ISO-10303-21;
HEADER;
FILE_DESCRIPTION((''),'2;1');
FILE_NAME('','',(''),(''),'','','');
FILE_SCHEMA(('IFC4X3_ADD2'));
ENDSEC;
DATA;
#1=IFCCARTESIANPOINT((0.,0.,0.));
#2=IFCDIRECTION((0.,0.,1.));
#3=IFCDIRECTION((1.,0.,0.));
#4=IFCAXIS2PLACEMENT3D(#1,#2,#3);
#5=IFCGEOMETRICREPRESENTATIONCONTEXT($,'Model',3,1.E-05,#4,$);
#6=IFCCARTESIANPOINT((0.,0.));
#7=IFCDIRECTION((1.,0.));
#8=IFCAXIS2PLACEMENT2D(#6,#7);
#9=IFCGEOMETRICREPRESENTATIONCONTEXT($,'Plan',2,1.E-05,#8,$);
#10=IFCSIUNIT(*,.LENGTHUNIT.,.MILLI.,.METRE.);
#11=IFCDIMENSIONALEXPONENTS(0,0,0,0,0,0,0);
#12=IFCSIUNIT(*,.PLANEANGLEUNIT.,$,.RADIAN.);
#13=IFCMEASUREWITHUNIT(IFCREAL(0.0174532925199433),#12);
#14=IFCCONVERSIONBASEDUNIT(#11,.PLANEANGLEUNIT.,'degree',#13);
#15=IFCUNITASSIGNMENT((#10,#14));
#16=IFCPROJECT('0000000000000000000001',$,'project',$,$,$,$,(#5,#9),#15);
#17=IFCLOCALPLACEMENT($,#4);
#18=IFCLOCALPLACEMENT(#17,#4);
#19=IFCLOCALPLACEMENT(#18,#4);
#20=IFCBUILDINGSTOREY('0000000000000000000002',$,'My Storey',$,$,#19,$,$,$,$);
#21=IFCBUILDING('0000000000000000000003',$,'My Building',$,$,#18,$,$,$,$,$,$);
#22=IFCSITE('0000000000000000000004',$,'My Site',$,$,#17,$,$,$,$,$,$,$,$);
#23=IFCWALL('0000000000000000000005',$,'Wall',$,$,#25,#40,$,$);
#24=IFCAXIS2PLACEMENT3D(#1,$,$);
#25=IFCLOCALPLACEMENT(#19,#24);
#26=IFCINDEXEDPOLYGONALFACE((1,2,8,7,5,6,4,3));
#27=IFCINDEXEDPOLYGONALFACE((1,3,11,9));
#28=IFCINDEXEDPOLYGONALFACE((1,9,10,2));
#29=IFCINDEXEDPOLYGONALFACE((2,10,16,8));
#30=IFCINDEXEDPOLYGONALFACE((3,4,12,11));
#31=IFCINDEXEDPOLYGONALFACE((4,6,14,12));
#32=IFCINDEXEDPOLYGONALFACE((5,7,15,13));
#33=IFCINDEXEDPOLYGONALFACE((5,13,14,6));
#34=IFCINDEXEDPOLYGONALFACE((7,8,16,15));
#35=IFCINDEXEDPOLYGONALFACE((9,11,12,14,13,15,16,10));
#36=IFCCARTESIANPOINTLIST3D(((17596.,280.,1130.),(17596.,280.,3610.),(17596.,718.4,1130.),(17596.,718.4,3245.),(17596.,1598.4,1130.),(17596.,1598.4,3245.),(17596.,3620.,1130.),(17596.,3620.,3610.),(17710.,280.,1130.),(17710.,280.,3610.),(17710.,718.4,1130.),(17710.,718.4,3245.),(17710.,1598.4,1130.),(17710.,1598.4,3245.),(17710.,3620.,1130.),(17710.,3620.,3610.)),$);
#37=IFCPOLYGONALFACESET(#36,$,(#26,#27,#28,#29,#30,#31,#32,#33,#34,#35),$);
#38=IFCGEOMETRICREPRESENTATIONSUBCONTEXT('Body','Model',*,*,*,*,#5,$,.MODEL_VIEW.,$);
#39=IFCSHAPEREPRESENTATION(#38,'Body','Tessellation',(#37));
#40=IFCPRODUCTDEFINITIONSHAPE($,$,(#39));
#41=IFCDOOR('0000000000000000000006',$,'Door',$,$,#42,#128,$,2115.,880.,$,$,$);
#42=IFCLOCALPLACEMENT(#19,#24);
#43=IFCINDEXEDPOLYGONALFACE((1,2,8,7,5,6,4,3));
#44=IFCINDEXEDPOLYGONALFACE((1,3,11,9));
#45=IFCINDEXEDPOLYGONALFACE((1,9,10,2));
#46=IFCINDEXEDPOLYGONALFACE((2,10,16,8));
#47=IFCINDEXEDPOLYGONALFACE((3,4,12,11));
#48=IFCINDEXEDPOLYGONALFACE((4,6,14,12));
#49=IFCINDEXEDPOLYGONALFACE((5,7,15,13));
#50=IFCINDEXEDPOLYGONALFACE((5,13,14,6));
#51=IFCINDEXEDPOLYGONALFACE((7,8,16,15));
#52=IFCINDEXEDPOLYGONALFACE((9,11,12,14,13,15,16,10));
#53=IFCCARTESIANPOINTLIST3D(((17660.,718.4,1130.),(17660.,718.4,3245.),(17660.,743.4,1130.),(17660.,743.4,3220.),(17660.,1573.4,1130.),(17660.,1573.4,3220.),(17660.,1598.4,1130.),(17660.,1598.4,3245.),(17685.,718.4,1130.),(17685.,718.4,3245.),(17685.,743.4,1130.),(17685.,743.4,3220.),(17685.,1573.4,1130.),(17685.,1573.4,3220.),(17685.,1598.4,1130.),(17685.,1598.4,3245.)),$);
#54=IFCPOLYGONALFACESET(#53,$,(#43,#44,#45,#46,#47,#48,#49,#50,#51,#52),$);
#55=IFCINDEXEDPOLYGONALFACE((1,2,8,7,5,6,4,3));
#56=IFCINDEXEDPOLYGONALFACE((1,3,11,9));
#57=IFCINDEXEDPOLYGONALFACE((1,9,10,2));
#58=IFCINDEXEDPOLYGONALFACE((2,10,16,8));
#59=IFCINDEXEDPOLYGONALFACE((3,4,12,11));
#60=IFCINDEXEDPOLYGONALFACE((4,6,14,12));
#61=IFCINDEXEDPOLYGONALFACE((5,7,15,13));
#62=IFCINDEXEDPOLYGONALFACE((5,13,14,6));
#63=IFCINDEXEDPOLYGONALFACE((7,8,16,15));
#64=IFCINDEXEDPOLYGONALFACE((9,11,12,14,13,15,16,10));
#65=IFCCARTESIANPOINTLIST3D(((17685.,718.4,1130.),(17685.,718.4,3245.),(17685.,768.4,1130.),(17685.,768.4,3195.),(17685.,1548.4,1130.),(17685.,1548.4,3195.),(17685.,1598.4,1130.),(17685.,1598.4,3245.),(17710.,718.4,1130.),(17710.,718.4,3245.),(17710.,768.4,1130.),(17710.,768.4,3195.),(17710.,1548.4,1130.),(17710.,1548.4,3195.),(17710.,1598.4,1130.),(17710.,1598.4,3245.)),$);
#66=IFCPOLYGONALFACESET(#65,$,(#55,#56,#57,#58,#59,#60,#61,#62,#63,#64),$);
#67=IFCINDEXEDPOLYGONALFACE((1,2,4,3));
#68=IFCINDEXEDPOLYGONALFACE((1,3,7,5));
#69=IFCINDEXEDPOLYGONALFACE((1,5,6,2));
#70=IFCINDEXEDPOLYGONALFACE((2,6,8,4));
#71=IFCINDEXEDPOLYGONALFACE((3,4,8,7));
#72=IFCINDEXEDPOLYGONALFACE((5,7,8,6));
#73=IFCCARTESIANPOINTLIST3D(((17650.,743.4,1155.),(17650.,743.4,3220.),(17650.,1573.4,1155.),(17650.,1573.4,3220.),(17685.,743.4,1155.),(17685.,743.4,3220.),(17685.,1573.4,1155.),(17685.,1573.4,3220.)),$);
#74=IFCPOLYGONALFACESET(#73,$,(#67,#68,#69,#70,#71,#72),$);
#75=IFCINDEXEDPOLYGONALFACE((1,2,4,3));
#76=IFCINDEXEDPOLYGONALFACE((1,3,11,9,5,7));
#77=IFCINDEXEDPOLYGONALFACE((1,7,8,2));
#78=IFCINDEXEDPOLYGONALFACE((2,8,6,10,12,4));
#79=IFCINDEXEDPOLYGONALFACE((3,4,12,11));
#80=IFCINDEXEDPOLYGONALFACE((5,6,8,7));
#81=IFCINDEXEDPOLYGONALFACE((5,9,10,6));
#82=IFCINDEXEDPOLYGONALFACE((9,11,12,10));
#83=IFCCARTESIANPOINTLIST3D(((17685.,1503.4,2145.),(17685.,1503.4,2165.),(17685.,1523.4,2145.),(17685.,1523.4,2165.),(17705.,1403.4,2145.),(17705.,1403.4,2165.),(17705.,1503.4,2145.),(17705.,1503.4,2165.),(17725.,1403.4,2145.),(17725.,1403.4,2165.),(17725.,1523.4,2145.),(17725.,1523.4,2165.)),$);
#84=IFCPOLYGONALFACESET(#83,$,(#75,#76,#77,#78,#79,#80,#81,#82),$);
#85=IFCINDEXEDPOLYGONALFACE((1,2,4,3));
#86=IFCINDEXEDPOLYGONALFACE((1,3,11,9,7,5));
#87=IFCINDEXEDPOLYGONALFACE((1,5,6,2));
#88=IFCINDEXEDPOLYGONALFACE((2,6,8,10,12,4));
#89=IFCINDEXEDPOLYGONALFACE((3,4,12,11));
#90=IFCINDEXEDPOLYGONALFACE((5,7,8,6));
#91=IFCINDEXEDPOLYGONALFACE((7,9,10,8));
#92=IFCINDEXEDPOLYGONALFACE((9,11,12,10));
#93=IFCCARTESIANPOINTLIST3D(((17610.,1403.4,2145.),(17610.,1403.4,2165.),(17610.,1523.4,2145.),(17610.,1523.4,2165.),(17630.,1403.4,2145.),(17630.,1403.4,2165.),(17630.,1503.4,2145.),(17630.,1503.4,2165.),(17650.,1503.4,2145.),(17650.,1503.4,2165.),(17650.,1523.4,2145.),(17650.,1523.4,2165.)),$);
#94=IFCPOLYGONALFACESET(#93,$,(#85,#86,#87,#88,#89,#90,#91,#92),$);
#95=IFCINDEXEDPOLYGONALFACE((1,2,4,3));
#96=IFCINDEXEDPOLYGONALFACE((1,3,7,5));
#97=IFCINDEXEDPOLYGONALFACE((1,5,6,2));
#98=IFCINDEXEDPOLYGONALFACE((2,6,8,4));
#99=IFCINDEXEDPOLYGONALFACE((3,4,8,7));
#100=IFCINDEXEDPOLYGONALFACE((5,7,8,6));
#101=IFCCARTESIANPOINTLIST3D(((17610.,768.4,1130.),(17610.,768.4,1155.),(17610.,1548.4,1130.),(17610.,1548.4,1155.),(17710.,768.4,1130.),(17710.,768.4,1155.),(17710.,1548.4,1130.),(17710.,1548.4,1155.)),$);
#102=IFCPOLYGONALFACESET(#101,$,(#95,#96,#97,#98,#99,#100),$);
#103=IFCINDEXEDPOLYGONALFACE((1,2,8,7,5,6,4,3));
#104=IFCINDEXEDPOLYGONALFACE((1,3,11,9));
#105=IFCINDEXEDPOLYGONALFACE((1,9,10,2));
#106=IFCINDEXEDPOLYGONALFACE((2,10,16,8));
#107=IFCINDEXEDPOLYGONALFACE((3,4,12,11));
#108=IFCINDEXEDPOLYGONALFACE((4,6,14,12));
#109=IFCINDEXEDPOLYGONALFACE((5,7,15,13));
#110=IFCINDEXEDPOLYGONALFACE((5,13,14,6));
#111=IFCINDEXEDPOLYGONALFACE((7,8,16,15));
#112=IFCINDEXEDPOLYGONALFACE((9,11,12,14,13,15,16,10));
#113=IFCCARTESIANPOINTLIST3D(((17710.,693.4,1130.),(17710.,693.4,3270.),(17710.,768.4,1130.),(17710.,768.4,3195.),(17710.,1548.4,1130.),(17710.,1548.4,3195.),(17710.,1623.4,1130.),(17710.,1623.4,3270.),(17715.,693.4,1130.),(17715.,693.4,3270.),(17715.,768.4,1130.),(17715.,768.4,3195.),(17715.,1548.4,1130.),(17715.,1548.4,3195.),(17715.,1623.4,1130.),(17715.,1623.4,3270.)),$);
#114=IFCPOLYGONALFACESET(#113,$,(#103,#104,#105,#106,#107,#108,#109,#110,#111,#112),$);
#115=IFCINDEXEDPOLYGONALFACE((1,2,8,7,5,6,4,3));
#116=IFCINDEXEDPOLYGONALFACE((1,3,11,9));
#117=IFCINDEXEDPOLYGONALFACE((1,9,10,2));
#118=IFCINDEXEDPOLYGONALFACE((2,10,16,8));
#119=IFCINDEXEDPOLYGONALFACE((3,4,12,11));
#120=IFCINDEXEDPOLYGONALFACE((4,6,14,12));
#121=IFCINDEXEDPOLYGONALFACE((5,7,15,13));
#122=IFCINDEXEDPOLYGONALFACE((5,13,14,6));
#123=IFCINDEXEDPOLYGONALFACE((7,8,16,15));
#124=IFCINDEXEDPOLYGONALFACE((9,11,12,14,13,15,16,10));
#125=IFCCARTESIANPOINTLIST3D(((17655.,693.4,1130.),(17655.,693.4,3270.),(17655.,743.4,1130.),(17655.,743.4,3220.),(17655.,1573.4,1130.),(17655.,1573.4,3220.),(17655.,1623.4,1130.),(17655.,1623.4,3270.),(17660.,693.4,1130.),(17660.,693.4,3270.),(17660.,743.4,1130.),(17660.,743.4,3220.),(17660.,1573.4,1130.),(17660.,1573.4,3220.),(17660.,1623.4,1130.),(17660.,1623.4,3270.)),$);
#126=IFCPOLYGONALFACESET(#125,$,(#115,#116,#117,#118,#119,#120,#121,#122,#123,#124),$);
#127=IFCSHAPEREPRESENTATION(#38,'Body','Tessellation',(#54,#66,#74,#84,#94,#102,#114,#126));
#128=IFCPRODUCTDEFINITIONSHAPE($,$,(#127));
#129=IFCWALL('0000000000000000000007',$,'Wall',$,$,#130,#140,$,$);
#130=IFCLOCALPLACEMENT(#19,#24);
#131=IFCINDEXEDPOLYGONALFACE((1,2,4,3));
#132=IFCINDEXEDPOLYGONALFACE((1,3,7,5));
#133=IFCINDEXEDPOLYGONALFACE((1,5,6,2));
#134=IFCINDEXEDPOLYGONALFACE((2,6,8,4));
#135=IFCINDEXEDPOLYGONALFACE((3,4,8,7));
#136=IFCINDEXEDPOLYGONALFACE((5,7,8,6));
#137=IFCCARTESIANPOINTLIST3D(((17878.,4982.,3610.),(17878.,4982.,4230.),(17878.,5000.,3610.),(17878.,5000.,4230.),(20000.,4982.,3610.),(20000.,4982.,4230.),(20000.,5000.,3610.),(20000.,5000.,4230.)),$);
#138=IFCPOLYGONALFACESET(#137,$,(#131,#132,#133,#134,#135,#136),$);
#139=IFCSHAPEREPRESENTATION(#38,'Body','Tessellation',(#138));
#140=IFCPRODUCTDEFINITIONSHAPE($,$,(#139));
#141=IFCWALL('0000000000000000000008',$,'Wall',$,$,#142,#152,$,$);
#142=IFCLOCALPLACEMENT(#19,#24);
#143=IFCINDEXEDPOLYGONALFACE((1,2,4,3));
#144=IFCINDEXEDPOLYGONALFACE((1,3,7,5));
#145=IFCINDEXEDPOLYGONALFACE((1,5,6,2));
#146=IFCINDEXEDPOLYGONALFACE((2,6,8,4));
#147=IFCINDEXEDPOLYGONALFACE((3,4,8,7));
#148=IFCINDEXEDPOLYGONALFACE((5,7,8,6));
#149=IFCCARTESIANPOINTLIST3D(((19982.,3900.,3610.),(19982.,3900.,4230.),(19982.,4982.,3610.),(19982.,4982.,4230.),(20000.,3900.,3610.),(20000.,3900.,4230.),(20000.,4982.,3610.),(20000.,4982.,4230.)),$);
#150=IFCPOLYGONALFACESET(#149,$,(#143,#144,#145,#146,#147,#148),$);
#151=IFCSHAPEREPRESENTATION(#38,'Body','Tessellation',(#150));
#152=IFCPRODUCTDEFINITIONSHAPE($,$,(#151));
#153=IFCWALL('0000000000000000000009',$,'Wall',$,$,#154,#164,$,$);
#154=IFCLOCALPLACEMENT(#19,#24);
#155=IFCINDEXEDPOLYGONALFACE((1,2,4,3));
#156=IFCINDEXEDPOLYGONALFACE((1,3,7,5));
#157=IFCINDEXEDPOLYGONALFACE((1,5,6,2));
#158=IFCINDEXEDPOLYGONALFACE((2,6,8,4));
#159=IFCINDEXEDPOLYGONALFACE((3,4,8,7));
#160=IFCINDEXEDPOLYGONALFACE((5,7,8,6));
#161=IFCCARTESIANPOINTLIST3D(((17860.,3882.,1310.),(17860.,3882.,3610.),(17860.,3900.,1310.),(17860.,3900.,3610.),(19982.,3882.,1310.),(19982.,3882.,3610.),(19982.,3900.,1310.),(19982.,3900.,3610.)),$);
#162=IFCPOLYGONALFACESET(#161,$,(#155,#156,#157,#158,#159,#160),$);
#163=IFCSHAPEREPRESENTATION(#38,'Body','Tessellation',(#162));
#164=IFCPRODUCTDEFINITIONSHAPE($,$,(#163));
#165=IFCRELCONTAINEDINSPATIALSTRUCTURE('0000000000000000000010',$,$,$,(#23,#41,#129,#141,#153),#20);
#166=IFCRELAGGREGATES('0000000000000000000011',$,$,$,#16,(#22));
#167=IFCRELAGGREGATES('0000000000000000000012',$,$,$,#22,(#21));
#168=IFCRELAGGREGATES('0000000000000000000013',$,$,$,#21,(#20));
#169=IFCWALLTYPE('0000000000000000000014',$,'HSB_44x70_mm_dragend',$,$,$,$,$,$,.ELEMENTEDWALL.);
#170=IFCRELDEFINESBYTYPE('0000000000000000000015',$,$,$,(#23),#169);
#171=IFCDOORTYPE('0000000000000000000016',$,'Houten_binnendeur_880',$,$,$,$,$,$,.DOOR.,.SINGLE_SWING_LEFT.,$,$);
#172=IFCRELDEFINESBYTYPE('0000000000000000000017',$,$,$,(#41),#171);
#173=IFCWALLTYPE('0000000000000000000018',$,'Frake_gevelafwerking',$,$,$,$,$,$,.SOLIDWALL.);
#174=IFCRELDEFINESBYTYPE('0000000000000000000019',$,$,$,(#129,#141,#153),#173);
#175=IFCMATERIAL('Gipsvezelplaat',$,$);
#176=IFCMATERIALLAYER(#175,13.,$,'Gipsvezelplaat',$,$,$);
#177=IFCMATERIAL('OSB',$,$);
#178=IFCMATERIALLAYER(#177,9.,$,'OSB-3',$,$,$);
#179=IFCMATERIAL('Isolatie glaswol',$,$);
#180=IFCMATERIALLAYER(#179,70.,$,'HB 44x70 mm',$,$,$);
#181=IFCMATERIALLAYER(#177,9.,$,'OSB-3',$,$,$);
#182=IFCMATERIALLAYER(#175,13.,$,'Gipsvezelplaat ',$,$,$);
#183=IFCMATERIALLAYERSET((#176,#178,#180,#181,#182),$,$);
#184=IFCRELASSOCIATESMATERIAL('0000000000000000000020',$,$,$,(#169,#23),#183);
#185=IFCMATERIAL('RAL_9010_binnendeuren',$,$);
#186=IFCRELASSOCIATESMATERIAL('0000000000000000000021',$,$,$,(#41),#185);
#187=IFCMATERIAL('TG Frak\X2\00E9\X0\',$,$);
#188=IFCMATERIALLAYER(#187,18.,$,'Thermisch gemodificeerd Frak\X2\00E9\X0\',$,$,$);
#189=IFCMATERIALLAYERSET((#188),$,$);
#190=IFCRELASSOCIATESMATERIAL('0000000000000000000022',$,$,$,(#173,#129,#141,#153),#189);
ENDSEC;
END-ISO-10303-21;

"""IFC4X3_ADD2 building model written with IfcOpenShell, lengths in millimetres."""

from ifc_helpers import new_model, entity, si_unit, converted_unit, frame, origin_with_axes, origin_2d_with_axis, place, context, subcontext, project, spatial, line, indexed_curve, outline, extrude, shape, source, transform, mapped, material, layer, layer_set, layer_usage, type_object, type_shapes, element, fill, save


model = new_model("IFC4X3_ADD2")

# Units and contexts
model_context = context("Model", 3, precision=1e-05, world=origin_with_axes())
plan_context = context("Plan", 2, precision=1e-05, world=origin_2d_with_axis())
body_context_1 = subcontext(model_context, "Body", "Model", "MODEL_VIEW")
body_context_2 = subcontext(plan_context, "Body", "Plan", "PLAN_VIEW")
ifc_project = project(units=[si_unit("LENGTHUNIT", "METRE", prefix="MILLI"), converted_unit("PLANEANGLEUNIT", "degree", entity("IfcReal", 0.0174532925199433), si_unit("PLANEANGLEUNIT", "RADIAN"), dimensions=[0, 0, 0, 0, 0, 0, 0])], contexts=[model_context, plan_context])

# Site, building, storey
site_placement = place(None, origin_with_axes())
site = spatial("IfcSite", under=ifc_project, at=site_placement, Name="My Site")
building_placement = place(site_placement, origin_with_axes())
building = spatial("IfcBuilding", under=site, at=building_placement, Name="My Building")
storey_placement = place(building_placement, origin_with_axes())
storey = spatial("IfcBuildingStorey", under=building, at=storey_placement, Name="My Storey")

# Shared definitions
ifc_material_1 = material(Name="Isolatie glaswol")

# Shared definitions
ifc_material_2 = material(Name="OSB")
ifc_material_3 = material(Name="Gipsvezelplaat")

# Wall, opening, door
shared_shape_1 = source(origin_with_axes(), body_context_1, "Body", "SweptSolid", [
    extrude(outline(indexed_curve([(0.0, 0.0), (880.0, 0.0), (880.0, 2115.0), (0.0, 2115.0)], segments=[line(1, 2, 3, 4, 1)])), frame((0.0, -600.0, 0.0), z_axis=(0.0, -1.0, 0.0), x_axis=(1.0, 0.0, 0.0)), (0.0, 0.0, -1.0), 1200.0),
])
ifc_material_4 = material(Name="RAL_9010_binnendeuren")
door_type_1 = type_object("IfcDoorType", Name="Houten_binnendeur_880", OperationType="SINGLE_SWING_LEFT", PredefinedType="DOOR")
shared_shape_2 = source(origin_with_axes(), body_context_1, "Body", "SweptSolid", [
    extrude(outline(indexed_curve([(0.0, 0.0), (0.0, 2115.0), (880.0, 2115.0), (880.0, 0.0), (855.0, 0.0), (855.0, 2090.0), (25.0, 2090.0), (25.0, 0.0)], segments=[line(1, 2, 3, 4, 5, 6, 7, 8, 1)])), frame((0.0, 25.0, 0.0), z_axis=(0.0, -1.0, 0.0), x_axis=(1.0, 0.0, 0.0)), (0.0, 0.0, -1.0), 25.0),
    extrude(outline(indexed_curve([(0.0, 0.0), (0.0, 2115.0), (880.0, 2115.0), (880.0, 0.0), (830.0, 0.0), (830.0, 2065.0), (50.0, 2065.0), (50.0, 0.0)], segments=[line(1, 2, 3, 4, 5, 6, 7, 8, 1)])), frame((0.0, 0.0, 0.0), z_axis=(0.0, -1.0, 0.0), x_axis=(1.0, 0.0, 0.0)), (0.0, 0.0, -1.0), 25.0),
    extrude(outline(indexed_curve([(0.0, 0.0), (830.0, 0.0), (830.0, 35.0), (0.0, 35.0)], segments=[line(1, 2, 3, 4, 1)])), frame((25.0, 25.0, 25.0), z_axis=(0.0, 0.0, 1.0), x_axis=(1.0, 0.0, 0.0)), (0.0, 0.0, 1.0), 2065.0),
    extrude(outline(indexed_curve([(0.0, 0.0), (0.0, -40.0), (-120.0, -40.0), (-120.0, -20.0), (-20.0, -20.0), (-20.0, 0.0)], segments=[line(1, 2, 3, 4, 5, 6, 1)])), frame((805.0, 25.0, 1015.0), z_axis=(0.0, 0.0, 1.0), x_axis=(1.0, 0.0, 0.0)), (0.0, 0.0, 1.0), 20.0),
    extrude(outline(indexed_curve([(0.0, 0.0), (0.0, 40.0), (-120.0, 40.0), (-120.0, 20.0), (-20.0, 20.0), (-20.0, 0.0)], segments=[line(1, 2, 3, 4, 5, 6, 1)])), frame((805.0, 60.0, 1015.0), z_axis=(0.0, 0.0, 1.0), x_axis=(1.0, 0.0, 0.0)), (0.0, 0.0, 1.0), 20.0),
    extrude(outline(indexed_curve([(0.0, 0.0), (780.0, 0.0), (780.0, 100.0), (0.0, 100.0)], segments=[line(1, 2, 3, 4, 1)])), frame((50.0, 0.0, 0.0), z_axis=(0.0, 0.0, 1.0), x_axis=(1.0, 0.0, 0.0)), (0.0, 0.0, 1.0), 25.0),
    extrude(outline(indexed_curve([(0.0, 0.0), (0.0, 2140.0), (930.0, 2140.0), (930.0, 0.0), (855.0, 0.0), (855.0, 2065.0), (75.0, 2065.0), (75.0, 0.0)], segments=[line(1, 2, 3, 4, 5, 6, 7, 8, 1)])), frame((-25.0, -5.0, 0.0), z_axis=(0.0, -1.0, 0.0), x_axis=(1.0, 0.0, 0.0)), (0.0, 0.0, -1.0), 5.0),
    extrude(outline(indexed_curve([(0.0, 0.0), (0.0, 2140.0), (930.0, 2140.0), (930.0, 0.0), (880.0, 0.0), (880.0, 2090.0), (50.0, 2090.0), (50.0, 0.0)], segments=[line(1, 2, 3, 4, 5, 6, 7, 8, 1)])), frame((-25.0, 50.0, 0.0), z_axis=(0.0, -1.0, 0.0), x_axis=(1.0, 0.0, 0.0)), (0.0, 0.0, -1.0), 5.0),
])
shared_shape_3 = source(origin_with_axes(), body_context_2, "Body", "Curve2D", [
    entity("IfcIndexedPolyCurve", entity("IfcCartesianPointList2D", [[0.0, 0.0], [0.0, 50.0], [25.0, 50.0], [25.0, 25.0], [50.0, 25.0], [50.0, 0.0]]), [entity("IfcLineIndex", [1, 2, 3, 4, 5, 6, 1])]),
    entity("IfcIndexedPolyCurve", entity("IfcCartesianPointList2D", [[880.0, 0.0], [880.0, 50.0], [855.0, 50.0], [855.0, 25.0], [830.0, 25.0], [830.0, 0.0]]), [entity("IfcLineIndex", [1, 2, 3, 4, 5, 6, 1])]),
    entity("IfcTrimmedCurve", entity("IfcEllipse", entity("IfcAxis2Placement2D", entity("IfcCartesianPoint", [60.0, 50.0]), entity("IfcDirection", [1.0, 0.0])), 795.0, 830.0), [entity("IfcCartesianPoint", [855.0, 50.0])], [entity("IfcCartesianPoint", [60.0, 880.0])], True, "CARTESIAN"),
    entity("IfcIndexedPolyCurve", entity("IfcCartesianPointList2D", [[25.0, 50.0], [60.0, 50.0], [60.0, 880.0], [25.0, 880.0]]), [entity("IfcLineIndex", [1, 2, 3, 4, 1])]),
])
type_shapes(door_type_1, [shared_shape_2, shared_shape_3])
ifc_layer_1 = layer(ifc_material_3, 13.0, Name="Gipsvezelplaat")
ifc_layer_2 = layer(ifc_material_2, 9.0, Name="OSB-3")
ifc_layer_3 = layer(ifc_material_1, 70.0, Name="HB 44x70 mm")
ifc_layer_4 = layer(ifc_material_2, 9.0, Name="OSB-3")
ifc_layer_5 = layer(ifc_material_3, 13.0, Name="Gipsvezelplaat ")
ifc_layer_set_1 = layer_set([ifc_layer_1, ifc_layer_2, ifc_layer_3, ifc_layer_4, ifc_layer_5])
ifc_layer_usage_1 = layer_usage(ifc_layer_set_1, "AXIS2", "POSITIVE", 0.0)
wall_type_1 = type_object("IfcWallType", Name="HSB_44x70_mm_dragend", PredefinedType="ELEMENTEDWALL", material=ifc_layer_set_1)
wall_1_placement = place(storey_placement, frame((17710.0, 280.0, 1130.0), z_axis=(0.0, 0.0, 1.0), x_axis=(0.0, 1.0, 0.0)))
wall_1 = element("IfcWall", 1, at=wall_1_placement, inside=storey, type_object=wall_type_1, material=ifc_layer_usage_1, Name="Wall", context=body_context_1, shape_type="SweptSolid", body=[
    extrude(outline(indexed_curve([(0.0, 0.0), (0.0, 114.0), (3340.0, 114.0), (3340.0, 0.0), (0.0, 0.0)], self_intersect=False)), origin_with_axes(), (0.0, 0.0, 1.0), 2480.0),
])
opening_1_placement = place(wall_1_placement, frame((438.4, 0.0, 0.0), z_axis=(0.0, 0.0, 1.0), x_axis=(1.0, 0.0, 0.0)))
opening_1 = element("IfcOpeningElement", 2, at=opening_1_placement, cuts=wall_1, PredefinedType="OPENING", context=body_context_1, shape_type="MappedRepresentation", body=[
    mapped(shared_shape_1, transform((0.0, 0.0, 0.0), x_axis=(1.0, 0.0, 0.0), y_axis=(0.0, 1.0, 0.0), z_axis=(0.0, 0.0, 1.0), scale=1.0)),
])
door_1_placement = place(opening_1_placement, origin_with_axes())
door_1 = element("IfcDoor", 3, at=door_1_placement, inside=storey, type_object=door_type_1, material=ifc_material_4, Name="Door", OverallHeight=2115.0, OverallWidth=880.0, shapes=[
    shape(body_context_1, "Body", "MappedRepresentation", [mapped(shared_shape_2, transform((0.0, 0.0, 0.0), x_axis=(1.0, 0.0, 0.0), y_axis=(0.0, 1.0, 0.0), z_axis=(0.0, 0.0, 1.0), scale=1.0))]),
    shape(body_context_2, "Body", "MappedRepresentation", [mapped(shared_shape_3, transform((0.0, 0.0, 0.0), x_axis=(1.0, 0.0, 0.0), y_axis=(0.0, 1.0, 0.0), z_axis=(0.0, 0.0, 1.0), scale=1.0))]),
])
fill(opening_1, door_1)

# Walls
ifc_material_5 = material(Name="TG Fraké")
ifc_layer_6 = layer(ifc_material_5, 18.0, Name="Thermisch gemodificeerd Fraké")
ifc_layer_set_2 = layer_set([ifc_layer_6])
ifc_layer_usage_2 = layer_usage(ifc_layer_set_2, "AXIS2", "POSITIVE", 0.0)
wall_type_2 = type_object("IfcWallType", Name="Frake_gevelafwerking", PredefinedType="SOLIDWALL", material=ifc_layer_set_2)
wall_2_placement = place(storey_placement, frame((17878.0, 4982.0, 3610.0), z_axis=(0.0, 0.0, 1.0), x_axis=(1.0, 0.0, 0.0)))
element("IfcWall", 4, at=wall_2_placement, inside=storey, type_object=wall_type_2, material=ifc_layer_usage_2, Name="Wall", context=body_context_1, shape_type="SweptSolid", body=[
    extrude(outline(indexed_curve([(0.0, 0.0), (0.0, 18.0), (2122.0, 18.0), (2122.0, 0.0), (0.0, 0.0)], self_intersect=False)), origin_with_axes(), (0.0, 0.0, 1.0), 620.0),
])
ifc_layer_usage_3 = layer_usage(ifc_layer_set_2, "AXIS2", "POSITIVE", 0.0)
wall_3_placement = place(storey_placement, frame((20000.0, 3900.0, 3610.0), z_axis=(0.0, 0.0, 1.0), x_axis=(0.0, 1.0, 0.0)))
element("IfcWall", 5, at=wall_3_placement, inside=storey, type_object=wall_type_2, material=ifc_layer_usage_3, Name="Wall", context=body_context_1, shape_type="SweptSolid", body=[
    extrude(outline(indexed_curve([(0.0, 0.0), (0.0, 18.0), (1082.0, 18.0), (1082.0, 0.0), (0.0, 0.0)], self_intersect=False)), origin_with_axes(), (0.0, 0.0, 1.0), 620.0),
])
ifc_layer_usage_4 = layer_usage(ifc_layer_set_2, "AXIS2", "POSITIVE", 0.0)
wall_4_placement = place(storey_placement, frame((17860.0, 3882.0, 1310.0), z_axis=(0.0, 0.0, 1.0), x_axis=(1.0, 0.0, 0.0)))
element("IfcWall", 6, at=wall_4_placement, inside=storey, type_object=wall_type_2, material=ifc_layer_usage_4, Name="Wall", context=body_context_1, shape_type="SweptSolid", body=[
    extrude(outline(indexed_curve([(0.0, 0.0), (0.0, 18.0), (2122.0, 18.0), (2122.0, 0.0), (0.0, 0.0)], self_intersect=False)), origin_with_axes(), (0.0, 0.0, 1.0), 2300.0),
])

save(model, "model.ifc")
